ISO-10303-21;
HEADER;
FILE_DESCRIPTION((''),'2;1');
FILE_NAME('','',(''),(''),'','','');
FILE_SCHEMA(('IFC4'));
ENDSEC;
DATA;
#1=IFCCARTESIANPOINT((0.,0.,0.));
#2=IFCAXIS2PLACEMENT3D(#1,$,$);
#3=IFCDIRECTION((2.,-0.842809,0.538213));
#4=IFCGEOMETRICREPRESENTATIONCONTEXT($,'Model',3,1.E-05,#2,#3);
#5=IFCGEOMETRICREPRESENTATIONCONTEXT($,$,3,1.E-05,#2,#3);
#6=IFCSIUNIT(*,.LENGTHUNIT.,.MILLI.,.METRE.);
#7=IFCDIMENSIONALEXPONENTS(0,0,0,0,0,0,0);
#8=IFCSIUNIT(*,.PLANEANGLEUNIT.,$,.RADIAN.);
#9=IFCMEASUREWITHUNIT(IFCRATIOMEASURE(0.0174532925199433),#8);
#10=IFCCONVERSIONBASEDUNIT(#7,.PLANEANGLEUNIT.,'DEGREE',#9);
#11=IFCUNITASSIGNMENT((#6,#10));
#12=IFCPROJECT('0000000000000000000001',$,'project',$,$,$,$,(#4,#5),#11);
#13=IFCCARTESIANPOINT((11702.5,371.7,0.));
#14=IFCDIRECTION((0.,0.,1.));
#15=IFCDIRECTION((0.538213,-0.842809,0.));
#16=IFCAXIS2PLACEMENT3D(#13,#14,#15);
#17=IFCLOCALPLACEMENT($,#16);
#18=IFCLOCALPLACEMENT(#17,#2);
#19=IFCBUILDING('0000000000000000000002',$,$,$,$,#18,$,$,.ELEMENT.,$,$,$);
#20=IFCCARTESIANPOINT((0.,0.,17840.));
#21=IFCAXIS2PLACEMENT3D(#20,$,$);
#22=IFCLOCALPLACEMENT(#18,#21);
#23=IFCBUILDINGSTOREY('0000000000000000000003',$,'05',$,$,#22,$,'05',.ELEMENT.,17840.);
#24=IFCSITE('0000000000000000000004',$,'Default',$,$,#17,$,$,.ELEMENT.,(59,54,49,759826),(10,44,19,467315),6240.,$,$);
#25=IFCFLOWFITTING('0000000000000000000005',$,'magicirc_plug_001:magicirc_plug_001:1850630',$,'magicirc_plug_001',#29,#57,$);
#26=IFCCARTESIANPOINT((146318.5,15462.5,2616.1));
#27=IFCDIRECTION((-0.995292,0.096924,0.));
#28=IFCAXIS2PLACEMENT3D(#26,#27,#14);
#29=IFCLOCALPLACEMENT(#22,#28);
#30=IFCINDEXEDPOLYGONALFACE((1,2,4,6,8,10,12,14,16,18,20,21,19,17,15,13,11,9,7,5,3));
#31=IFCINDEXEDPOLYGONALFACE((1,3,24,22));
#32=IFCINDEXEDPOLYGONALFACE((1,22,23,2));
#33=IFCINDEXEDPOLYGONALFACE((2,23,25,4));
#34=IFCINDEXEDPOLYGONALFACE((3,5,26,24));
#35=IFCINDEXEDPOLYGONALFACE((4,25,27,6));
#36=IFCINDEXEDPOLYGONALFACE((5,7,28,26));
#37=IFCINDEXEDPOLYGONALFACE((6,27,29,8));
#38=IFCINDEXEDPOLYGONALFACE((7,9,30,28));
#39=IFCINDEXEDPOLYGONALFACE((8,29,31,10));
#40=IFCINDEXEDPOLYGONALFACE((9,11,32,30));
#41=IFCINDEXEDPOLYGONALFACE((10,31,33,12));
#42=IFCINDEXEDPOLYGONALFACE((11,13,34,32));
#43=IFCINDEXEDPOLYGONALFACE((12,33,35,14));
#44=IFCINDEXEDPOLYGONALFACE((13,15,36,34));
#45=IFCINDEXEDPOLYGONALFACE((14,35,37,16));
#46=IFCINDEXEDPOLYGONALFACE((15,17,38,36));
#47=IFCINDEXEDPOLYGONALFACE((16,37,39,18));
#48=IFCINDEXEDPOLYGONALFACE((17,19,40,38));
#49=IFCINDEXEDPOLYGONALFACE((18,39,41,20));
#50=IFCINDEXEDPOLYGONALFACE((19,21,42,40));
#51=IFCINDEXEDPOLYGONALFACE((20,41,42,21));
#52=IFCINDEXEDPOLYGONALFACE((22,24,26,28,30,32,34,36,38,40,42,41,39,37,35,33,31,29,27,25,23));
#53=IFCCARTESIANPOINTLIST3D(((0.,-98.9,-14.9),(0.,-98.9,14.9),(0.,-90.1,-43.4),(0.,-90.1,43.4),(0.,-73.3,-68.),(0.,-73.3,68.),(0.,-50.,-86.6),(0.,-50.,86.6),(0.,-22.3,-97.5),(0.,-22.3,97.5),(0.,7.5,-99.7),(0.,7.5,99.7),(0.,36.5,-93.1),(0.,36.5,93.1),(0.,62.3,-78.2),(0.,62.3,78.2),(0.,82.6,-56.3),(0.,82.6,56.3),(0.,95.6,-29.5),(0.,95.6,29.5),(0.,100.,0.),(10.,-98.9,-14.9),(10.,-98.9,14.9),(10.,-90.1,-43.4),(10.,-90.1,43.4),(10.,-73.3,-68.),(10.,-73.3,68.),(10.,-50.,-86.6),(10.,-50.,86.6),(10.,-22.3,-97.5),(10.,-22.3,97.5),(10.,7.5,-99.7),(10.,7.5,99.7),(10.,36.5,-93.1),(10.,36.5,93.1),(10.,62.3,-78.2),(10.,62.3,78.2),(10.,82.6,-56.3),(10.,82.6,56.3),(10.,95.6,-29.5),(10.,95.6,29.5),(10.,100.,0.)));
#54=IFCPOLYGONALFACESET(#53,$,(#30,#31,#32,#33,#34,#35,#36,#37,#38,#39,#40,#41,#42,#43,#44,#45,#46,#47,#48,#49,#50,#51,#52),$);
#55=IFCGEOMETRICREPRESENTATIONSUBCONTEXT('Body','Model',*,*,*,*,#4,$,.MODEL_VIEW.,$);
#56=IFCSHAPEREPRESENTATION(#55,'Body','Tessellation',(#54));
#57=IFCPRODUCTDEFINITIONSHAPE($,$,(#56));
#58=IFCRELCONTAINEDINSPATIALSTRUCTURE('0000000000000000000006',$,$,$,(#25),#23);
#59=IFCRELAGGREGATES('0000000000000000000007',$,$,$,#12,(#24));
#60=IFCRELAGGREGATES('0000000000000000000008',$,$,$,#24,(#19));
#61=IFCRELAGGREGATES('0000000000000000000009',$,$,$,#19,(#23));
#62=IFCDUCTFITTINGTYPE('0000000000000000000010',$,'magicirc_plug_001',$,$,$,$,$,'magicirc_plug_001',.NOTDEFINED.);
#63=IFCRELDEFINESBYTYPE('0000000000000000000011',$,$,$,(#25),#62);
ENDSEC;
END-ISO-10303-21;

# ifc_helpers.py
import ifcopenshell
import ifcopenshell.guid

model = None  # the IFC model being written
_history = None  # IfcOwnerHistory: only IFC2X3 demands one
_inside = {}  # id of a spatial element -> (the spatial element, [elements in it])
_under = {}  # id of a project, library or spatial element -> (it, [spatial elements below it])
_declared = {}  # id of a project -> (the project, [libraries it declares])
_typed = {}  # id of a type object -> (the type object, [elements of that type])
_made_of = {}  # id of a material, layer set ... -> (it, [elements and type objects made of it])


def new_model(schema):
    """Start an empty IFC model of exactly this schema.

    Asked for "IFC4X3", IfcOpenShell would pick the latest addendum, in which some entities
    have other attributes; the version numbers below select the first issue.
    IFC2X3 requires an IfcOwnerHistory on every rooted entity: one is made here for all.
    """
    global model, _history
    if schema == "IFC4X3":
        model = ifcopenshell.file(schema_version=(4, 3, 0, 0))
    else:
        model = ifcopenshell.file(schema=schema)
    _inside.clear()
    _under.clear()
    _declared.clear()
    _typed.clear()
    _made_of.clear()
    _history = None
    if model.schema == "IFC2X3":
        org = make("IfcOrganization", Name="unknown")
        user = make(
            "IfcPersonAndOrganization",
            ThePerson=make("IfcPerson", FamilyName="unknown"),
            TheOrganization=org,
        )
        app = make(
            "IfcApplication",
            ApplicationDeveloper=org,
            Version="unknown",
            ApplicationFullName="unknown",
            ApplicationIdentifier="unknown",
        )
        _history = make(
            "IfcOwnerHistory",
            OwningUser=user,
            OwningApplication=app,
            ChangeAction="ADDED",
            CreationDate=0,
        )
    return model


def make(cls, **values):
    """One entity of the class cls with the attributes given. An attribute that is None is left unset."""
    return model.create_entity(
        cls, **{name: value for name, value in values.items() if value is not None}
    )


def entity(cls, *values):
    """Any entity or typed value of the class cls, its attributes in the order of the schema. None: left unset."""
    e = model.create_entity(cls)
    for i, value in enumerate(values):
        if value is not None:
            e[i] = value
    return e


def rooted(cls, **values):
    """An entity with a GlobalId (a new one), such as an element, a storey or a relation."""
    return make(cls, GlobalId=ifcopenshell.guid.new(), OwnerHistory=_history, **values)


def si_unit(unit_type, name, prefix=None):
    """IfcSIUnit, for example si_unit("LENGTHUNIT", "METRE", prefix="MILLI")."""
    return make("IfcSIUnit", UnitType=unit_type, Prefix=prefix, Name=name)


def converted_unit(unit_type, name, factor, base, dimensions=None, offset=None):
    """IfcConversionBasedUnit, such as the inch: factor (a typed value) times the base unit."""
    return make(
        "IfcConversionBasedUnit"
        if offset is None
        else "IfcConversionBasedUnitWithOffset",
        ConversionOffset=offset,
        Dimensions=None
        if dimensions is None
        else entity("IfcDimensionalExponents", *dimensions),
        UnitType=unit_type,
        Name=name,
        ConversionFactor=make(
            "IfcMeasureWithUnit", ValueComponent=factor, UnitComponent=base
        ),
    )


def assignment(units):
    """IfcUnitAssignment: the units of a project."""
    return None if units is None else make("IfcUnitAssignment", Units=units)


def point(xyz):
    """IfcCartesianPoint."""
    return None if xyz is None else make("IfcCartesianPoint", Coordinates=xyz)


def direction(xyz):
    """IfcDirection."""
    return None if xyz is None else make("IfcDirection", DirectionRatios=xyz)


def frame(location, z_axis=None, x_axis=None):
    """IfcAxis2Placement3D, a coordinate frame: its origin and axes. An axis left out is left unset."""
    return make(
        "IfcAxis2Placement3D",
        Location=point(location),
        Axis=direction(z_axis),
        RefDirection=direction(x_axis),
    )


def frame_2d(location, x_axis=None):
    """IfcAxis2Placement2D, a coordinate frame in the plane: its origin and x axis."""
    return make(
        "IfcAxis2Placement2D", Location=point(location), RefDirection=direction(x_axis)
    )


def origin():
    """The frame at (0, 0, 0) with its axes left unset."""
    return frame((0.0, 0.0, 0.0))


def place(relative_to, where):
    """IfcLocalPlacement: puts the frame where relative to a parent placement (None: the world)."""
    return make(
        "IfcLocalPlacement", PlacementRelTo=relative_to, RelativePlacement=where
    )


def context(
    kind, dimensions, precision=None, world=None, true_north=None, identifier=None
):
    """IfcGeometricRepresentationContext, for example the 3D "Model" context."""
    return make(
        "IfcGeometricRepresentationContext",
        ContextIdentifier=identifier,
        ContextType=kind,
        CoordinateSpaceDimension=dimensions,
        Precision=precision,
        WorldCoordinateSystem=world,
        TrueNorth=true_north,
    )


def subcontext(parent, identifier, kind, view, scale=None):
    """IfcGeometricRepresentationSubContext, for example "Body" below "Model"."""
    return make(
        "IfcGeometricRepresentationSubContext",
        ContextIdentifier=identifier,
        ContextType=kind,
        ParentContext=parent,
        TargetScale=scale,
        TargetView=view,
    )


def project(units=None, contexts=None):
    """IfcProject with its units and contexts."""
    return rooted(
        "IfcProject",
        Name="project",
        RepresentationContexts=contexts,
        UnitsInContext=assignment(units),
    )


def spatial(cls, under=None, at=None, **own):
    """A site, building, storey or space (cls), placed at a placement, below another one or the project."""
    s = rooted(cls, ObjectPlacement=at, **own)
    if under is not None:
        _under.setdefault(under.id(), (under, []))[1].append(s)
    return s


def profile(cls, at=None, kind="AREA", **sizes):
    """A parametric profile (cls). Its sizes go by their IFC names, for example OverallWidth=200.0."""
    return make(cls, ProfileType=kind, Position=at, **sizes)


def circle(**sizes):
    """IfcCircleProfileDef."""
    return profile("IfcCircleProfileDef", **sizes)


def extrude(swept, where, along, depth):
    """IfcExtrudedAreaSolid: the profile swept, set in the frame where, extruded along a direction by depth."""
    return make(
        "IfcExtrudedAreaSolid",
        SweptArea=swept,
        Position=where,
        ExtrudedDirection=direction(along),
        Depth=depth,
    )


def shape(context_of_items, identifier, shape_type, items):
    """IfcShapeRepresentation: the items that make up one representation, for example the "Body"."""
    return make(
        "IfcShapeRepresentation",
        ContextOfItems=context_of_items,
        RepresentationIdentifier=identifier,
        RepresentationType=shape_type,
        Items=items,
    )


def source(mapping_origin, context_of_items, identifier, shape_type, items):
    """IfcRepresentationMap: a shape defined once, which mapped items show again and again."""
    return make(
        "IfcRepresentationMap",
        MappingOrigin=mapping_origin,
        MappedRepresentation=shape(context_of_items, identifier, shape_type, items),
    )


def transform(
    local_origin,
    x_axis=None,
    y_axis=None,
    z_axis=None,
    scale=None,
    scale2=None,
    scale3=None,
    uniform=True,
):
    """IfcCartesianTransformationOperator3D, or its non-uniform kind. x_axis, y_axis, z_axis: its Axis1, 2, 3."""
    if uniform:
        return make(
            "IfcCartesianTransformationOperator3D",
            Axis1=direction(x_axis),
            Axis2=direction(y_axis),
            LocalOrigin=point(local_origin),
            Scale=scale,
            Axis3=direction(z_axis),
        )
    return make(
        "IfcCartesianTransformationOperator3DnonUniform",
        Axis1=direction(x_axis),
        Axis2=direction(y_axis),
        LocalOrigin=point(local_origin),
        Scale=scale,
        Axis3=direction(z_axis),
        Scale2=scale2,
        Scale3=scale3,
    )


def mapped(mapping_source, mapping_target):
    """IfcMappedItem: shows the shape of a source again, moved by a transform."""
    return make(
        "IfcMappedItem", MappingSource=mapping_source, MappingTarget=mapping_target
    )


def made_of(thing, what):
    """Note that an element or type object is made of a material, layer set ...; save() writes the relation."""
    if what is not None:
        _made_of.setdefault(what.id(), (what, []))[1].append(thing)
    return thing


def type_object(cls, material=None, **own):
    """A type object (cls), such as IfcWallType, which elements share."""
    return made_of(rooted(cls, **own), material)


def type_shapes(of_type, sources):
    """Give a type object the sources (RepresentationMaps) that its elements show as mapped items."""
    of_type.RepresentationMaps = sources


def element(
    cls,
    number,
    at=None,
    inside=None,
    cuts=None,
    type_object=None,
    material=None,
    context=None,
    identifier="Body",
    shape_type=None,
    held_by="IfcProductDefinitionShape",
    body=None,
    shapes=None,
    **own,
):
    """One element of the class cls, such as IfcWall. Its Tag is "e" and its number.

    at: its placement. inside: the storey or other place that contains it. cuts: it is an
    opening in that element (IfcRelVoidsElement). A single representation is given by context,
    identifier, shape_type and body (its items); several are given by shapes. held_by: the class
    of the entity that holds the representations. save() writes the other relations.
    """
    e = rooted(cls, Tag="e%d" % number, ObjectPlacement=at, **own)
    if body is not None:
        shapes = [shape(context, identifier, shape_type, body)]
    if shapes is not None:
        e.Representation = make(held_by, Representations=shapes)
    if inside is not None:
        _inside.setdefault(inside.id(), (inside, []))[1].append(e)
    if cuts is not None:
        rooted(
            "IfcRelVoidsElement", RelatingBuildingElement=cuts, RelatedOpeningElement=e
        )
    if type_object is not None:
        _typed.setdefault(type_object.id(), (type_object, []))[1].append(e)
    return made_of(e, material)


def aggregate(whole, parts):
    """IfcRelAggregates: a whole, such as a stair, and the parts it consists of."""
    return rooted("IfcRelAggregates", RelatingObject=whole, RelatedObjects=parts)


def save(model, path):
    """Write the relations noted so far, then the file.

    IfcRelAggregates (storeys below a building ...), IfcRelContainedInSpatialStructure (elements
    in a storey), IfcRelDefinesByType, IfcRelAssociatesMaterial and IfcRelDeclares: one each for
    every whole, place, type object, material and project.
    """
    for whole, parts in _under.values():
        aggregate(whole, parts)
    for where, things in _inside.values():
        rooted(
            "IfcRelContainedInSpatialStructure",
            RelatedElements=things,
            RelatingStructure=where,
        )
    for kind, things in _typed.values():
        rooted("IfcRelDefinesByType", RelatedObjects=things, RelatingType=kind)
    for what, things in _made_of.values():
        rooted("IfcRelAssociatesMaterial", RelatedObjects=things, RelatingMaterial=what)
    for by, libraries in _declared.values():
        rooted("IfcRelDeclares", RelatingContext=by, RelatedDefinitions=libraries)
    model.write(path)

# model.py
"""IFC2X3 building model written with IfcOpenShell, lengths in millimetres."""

from ifc_helpers import new_model, entity, si_unit, converted_unit, direction, frame, frame_2d, origin, place, context, subcontext, project, spatial, circle, extrude, source, transform, mapped, type_object, type_shapes, element, save


model = new_model("IFC2X3")

# Units and contexts
model_context = context("Model", 3, precision=1e-05, world=origin(), true_north=direction((2.0, -0.842809, 0.538213)))
context_of_model = context(None, 3, precision=1e-05, world=origin(), true_north=direction((2.0, -0.842809, 0.538213)))
body_context = subcontext(model_context, "Body", "Model", "MODEL_VIEW")
ifc_project = project(units=[si_unit("LENGTHUNIT", "METRE", prefix="MILLI"), converted_unit("PLANEANGLEUNIT", "DEGREE", entity("IfcRatioMeasure", 0.0174532925199433), si_unit("PLANEANGLEUNIT", "RADIAN"), dimensions=[0, 0, 0, 0, 0, 0, 0])], contexts=[model_context, context_of_model])

# Site, building, storey
site_placement = place(None, frame((11702.5, 371.7, 0.0), z_axis=(0.0, 0.0, 1.0), x_axis=(0.538213, -0.842809, 0.0)))
site = spatial("IfcSite", under=ifc_project, at=site_placement, Name="Default", CompositionType="ELEMENT", RefLatitude=(59, 54, 49, 759826), RefLongitude=(10, 44, 19, 467315), RefElevation=6240.0)
building_placement = place(site_placement, origin())
building = spatial("IfcBuilding", under=site, at=building_placement, CompositionType="ELEMENT")
storey_placement = place(building_placement, frame((0.0, 0.0, 17840.0)))
storey = spatial("IfcBuildingStorey", under=building, at=storey_placement, Name="05", LongName="05", CompositionType="ELEMENT", Elevation=17840.0)

# Flow fitting
duct_fitting_type_1 = type_object("IfcDuctFittingType", Name="magicirc_plug_001", ElementType="magicirc_plug_001", PredefinedType="NOTDEFINED")
shared_shape_1 = source(origin(), body_context, "Body", "SweptSolid", [
    extrude(circle(Radius=100.0, at=frame_2d((0.0, 0.0), x_axis=(1.0, 0.0))), frame((0.0, 0.0, 0.0), z_axis=(1.0, 0.0, 0.0), x_axis=(0.0, 1.0, 0.0)), (0.0, 0.0, 1.0), 10.0),
])
type_shapes(duct_fitting_type_1, [shared_shape_1])
flow_fitting_1_placement = place(storey_placement, frame((146318.5, 15462.5, 2616.1), z_axis=(-0.995292, 0.096924, 0.0), x_axis=(0.0, 0.0, 1.0)))
element("IfcFlowFitting", 1, at=flow_fitting_1_placement, inside=storey, type_object=duct_fitting_type_1, Name="magicirc_plug_001:magicirc_plug_001:1850630", ObjectType="magicirc_plug_001", context=body_context, shape_type="MappedRepresentation", body=[
    mapped(shared_shape_1, transform((0.0, 0.0, 0.0), scale=1.0)),
])

save(model, "model.ifc")
